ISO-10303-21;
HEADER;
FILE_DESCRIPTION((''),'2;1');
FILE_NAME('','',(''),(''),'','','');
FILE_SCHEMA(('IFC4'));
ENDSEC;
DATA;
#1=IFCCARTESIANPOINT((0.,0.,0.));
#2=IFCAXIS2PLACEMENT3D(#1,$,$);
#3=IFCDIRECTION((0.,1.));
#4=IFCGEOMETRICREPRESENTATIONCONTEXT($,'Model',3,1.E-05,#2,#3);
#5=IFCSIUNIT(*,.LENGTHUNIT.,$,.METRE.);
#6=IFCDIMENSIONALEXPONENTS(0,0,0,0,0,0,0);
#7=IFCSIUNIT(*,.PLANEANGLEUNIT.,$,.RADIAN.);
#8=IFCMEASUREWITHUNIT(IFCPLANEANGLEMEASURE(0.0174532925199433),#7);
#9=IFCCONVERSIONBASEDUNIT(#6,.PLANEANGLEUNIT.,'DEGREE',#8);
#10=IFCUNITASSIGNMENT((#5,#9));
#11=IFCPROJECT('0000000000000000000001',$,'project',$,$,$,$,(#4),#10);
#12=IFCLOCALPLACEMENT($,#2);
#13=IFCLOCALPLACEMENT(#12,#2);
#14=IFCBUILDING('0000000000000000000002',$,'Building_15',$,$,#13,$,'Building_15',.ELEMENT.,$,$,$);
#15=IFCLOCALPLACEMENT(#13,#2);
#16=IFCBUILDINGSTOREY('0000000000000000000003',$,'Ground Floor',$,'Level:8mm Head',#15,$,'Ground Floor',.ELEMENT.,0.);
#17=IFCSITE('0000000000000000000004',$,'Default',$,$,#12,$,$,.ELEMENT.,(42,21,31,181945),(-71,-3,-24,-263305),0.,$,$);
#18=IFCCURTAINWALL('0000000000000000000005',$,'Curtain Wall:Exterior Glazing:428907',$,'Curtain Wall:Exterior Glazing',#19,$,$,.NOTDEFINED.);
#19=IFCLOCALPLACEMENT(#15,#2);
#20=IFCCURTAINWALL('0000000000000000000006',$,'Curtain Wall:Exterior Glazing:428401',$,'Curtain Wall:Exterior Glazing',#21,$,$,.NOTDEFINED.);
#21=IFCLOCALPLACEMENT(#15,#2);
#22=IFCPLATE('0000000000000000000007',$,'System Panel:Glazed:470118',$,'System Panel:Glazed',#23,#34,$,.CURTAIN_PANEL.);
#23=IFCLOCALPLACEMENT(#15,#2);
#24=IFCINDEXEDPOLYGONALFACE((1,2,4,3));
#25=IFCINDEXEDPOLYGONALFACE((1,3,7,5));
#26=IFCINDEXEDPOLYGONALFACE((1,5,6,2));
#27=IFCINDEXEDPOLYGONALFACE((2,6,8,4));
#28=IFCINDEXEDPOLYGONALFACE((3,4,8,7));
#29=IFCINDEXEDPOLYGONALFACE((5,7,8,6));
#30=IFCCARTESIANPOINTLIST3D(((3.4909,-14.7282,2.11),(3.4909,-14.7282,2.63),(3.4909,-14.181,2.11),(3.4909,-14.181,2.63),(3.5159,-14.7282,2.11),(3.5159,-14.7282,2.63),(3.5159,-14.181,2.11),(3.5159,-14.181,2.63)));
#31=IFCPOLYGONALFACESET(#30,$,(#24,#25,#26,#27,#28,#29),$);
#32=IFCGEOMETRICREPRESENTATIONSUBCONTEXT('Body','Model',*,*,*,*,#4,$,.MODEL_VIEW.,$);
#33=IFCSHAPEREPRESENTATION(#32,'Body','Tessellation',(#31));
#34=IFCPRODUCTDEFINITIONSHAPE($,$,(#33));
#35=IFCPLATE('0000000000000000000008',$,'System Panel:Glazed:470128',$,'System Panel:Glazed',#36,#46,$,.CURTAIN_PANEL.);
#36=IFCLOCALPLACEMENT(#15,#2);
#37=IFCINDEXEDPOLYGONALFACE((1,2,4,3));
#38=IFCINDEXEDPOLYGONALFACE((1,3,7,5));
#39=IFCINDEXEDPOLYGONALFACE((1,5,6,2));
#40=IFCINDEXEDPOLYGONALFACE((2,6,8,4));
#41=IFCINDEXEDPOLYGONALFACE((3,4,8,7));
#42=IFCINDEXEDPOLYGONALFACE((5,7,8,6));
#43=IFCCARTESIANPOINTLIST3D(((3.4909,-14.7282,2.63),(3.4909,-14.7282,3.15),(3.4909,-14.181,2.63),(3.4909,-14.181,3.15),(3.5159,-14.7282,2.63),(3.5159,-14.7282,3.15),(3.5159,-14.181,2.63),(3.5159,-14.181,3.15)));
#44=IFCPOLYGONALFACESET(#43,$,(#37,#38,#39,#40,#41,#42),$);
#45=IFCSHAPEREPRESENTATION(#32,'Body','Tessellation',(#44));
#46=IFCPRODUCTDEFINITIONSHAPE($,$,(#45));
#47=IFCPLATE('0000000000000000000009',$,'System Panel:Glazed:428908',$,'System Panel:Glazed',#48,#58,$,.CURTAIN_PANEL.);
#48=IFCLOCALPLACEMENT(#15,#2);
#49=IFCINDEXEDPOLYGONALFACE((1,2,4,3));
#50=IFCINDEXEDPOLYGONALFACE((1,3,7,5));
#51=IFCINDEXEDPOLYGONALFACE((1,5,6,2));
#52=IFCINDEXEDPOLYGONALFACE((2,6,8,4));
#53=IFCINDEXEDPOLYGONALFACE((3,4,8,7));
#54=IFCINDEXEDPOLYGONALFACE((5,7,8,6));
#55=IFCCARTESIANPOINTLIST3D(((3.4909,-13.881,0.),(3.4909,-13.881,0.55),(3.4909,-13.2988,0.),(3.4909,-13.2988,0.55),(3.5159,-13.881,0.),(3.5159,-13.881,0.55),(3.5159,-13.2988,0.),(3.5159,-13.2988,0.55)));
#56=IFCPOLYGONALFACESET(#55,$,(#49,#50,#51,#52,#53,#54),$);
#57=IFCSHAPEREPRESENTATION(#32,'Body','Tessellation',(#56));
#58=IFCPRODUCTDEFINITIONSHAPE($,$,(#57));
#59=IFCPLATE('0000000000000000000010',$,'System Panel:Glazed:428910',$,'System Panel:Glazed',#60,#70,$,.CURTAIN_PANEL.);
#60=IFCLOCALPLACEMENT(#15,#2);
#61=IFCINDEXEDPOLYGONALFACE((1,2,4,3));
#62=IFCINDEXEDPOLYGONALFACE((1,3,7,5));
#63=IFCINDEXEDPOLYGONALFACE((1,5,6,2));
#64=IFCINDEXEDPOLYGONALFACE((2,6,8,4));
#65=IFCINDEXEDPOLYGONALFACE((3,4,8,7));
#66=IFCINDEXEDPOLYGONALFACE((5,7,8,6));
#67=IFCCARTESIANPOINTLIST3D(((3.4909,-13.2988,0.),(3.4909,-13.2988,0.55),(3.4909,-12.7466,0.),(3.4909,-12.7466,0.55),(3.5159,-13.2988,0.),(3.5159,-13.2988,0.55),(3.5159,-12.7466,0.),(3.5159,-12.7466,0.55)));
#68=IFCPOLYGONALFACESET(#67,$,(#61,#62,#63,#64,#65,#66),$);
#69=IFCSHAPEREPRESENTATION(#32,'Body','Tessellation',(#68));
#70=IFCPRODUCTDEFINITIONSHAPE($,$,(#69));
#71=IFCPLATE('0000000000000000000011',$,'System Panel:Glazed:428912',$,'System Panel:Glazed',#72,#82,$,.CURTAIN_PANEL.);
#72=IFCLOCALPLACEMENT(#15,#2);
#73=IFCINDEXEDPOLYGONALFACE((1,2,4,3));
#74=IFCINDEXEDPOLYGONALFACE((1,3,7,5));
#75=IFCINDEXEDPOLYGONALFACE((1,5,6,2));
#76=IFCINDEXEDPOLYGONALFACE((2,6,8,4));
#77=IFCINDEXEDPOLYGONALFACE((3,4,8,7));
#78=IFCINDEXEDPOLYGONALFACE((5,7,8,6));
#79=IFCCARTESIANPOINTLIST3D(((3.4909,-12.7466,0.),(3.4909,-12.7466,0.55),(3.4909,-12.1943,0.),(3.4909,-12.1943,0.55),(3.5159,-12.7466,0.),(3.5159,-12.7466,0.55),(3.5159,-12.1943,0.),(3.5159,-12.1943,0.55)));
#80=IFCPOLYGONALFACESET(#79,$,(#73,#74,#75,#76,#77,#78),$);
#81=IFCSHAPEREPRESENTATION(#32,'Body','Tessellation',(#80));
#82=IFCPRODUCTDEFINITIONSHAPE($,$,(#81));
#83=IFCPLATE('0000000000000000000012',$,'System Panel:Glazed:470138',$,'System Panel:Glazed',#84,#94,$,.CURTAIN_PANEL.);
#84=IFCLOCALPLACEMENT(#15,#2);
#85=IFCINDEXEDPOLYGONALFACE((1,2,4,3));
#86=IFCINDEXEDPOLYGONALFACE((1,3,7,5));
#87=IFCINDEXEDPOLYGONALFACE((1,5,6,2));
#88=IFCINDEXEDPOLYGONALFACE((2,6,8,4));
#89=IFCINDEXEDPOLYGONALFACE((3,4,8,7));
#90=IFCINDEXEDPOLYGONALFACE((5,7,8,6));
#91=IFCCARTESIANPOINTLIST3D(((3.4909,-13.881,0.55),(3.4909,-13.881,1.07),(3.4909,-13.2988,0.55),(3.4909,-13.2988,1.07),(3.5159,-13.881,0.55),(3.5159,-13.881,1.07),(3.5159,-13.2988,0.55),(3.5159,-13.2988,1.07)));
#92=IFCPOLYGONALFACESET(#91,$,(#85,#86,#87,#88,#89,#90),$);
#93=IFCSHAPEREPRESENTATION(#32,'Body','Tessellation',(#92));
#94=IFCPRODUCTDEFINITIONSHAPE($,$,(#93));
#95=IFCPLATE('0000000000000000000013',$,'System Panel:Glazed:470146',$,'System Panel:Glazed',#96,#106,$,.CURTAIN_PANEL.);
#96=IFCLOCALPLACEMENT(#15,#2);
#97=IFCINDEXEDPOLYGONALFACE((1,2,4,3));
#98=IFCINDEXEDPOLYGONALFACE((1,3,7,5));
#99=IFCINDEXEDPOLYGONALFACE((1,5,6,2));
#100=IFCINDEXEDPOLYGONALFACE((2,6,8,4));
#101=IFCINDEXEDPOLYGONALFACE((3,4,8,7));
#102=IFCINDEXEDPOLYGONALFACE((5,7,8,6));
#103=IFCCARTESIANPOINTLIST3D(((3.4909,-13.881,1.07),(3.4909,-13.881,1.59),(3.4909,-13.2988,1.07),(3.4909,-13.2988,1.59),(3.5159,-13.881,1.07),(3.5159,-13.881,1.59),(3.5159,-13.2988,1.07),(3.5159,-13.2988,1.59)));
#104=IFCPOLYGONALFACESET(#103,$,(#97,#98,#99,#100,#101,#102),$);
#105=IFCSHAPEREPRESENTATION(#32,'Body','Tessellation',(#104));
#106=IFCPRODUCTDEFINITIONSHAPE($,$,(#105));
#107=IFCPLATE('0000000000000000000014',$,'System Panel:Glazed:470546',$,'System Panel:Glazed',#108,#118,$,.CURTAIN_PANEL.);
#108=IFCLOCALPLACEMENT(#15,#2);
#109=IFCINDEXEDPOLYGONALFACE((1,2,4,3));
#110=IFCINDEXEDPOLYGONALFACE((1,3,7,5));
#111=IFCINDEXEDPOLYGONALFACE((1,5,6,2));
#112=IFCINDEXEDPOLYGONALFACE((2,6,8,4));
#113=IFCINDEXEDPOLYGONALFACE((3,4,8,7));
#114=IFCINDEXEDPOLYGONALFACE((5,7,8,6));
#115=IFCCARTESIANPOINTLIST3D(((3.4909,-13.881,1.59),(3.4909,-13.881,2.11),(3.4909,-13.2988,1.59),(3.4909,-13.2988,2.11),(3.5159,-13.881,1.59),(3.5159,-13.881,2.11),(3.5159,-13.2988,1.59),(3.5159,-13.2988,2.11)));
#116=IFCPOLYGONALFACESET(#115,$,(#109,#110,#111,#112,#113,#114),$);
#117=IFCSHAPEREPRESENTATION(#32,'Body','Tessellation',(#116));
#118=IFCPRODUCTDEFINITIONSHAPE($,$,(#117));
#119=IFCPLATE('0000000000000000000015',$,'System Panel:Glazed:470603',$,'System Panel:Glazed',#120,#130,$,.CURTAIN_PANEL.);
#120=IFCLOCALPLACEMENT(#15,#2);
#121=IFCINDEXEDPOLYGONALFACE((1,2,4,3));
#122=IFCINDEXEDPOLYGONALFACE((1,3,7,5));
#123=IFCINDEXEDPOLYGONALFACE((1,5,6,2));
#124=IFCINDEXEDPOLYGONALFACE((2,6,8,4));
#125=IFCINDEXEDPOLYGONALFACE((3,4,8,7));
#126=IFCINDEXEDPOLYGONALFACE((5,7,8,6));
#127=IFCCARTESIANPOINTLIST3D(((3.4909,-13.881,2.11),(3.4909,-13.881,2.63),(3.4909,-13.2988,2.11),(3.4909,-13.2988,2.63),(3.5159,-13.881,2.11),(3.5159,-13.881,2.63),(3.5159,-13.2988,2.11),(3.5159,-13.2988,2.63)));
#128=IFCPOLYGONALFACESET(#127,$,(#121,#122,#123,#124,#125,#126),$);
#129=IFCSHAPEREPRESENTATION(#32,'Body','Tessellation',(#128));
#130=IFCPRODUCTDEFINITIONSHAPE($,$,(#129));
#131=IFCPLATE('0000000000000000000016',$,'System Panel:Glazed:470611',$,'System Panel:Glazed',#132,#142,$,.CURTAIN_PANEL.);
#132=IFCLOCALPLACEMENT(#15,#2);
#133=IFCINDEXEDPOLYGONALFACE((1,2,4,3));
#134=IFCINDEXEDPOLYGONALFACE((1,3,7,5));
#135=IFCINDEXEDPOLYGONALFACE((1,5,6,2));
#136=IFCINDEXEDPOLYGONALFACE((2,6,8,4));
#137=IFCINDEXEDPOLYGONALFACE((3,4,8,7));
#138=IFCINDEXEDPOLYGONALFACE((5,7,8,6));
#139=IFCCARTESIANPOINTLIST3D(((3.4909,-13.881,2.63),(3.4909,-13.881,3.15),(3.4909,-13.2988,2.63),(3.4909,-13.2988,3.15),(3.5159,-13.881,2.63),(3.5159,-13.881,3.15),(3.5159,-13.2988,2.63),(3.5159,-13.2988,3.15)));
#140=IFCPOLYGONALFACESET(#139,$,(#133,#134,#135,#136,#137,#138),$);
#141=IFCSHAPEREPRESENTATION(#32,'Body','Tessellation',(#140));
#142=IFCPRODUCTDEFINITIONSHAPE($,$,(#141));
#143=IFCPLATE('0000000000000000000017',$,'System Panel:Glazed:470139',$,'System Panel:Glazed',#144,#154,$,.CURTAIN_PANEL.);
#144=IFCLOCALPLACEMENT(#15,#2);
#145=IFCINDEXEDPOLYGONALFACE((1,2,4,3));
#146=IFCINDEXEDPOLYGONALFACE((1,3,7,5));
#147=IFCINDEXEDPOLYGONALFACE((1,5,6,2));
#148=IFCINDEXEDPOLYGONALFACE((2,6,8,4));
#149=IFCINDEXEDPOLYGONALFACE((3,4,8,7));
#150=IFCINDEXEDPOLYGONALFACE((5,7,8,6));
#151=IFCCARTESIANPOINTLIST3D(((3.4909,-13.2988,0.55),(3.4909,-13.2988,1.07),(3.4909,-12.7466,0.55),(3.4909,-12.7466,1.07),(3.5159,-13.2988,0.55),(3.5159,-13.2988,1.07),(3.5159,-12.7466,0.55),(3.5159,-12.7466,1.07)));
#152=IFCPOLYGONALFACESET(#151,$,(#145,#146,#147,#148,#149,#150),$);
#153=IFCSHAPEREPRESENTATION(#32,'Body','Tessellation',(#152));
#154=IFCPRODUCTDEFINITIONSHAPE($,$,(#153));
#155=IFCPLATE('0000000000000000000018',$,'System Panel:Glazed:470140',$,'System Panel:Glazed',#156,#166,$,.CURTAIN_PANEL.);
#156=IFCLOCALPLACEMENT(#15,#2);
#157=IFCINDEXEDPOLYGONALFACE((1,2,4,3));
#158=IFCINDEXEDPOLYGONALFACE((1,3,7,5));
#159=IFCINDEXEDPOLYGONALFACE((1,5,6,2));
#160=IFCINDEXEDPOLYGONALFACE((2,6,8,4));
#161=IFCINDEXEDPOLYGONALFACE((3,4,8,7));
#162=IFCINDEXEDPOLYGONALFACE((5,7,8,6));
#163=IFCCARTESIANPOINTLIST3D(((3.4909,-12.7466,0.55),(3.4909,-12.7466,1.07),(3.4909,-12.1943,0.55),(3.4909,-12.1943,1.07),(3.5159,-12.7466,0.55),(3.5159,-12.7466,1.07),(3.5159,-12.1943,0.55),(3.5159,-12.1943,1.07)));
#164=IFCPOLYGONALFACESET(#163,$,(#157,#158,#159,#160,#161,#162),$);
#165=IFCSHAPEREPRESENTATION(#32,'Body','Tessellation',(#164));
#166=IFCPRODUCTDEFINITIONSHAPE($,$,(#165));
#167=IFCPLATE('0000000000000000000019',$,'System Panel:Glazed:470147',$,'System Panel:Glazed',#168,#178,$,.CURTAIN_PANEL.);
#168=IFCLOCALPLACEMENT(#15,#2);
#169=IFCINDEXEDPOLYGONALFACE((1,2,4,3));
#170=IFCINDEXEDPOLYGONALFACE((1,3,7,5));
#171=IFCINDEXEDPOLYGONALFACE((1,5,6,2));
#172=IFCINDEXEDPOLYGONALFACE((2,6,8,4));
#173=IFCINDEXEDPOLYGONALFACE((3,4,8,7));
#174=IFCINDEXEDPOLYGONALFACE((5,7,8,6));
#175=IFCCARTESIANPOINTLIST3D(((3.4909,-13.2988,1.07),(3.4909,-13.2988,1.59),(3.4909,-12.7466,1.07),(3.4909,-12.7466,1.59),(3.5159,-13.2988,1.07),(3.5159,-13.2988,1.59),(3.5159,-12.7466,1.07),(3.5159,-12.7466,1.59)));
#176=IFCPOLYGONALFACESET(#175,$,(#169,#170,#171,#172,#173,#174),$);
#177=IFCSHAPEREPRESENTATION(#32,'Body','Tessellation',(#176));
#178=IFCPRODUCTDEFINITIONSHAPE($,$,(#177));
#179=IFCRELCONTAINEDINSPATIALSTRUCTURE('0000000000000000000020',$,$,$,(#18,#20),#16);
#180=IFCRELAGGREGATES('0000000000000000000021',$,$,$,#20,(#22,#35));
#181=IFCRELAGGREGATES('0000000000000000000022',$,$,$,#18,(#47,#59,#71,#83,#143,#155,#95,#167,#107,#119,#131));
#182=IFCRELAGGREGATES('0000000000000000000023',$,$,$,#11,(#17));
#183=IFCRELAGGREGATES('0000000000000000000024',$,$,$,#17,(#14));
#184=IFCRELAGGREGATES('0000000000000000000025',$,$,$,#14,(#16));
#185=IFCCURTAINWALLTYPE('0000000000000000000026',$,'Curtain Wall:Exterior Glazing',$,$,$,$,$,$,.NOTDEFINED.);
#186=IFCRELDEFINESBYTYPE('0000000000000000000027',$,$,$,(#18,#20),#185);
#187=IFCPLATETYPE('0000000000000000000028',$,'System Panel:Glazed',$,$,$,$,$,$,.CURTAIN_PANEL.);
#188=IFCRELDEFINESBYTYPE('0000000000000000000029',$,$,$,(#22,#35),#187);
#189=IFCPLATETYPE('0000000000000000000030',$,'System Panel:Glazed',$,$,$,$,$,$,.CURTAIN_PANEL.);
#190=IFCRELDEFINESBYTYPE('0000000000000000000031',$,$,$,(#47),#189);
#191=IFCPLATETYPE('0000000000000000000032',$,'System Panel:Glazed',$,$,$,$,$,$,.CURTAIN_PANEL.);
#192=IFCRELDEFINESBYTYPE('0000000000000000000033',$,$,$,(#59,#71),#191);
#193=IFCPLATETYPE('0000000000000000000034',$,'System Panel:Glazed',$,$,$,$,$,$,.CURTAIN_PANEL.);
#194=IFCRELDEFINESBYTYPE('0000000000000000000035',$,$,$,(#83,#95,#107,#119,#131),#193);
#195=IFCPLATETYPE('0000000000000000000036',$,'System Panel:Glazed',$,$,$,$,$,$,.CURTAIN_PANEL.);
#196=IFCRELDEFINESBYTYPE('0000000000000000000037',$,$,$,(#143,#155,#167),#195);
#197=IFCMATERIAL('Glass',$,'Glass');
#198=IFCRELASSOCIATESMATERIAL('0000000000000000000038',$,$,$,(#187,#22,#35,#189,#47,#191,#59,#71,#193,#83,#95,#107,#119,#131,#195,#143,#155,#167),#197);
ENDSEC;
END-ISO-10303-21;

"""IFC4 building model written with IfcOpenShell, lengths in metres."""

from ifc_helpers import new_model, entity, si_unit, converted_unit, direction, frame, origin, place, context, subcontext, project, spatial, indexed_curve, outline, extrude, source, transform, mapped, material, type_object, type_shapes, element, aggregate, save


model = new_model("IFC4")

# Units and contexts
model_context = context("Model", 3, precision=1e-05, world=origin(), true_north=direction((0.0, 1.0)))
body_context = subcontext(model_context, "Body", "Model", "MODEL_VIEW")
ifc_project = project(units=[si_unit("LENGTHUNIT", "METRE"), converted_unit("PLANEANGLEUNIT", "DEGREE", entity("IfcPlaneAngleMeasure", 0.0174532925199433), si_unit("PLANEANGLEUNIT", "RADIAN"), dimensions=[0, 0, 0, 0, 0, 0, 0])], contexts=[model_context])

# Site, building, storey
site_placement = place(None, origin())
site = spatial("IfcSite", under=ifc_project, at=site_placement, Name="Default", CompositionType="ELEMENT", RefLatitude=(42, 21, 31, 181945), RefLongitude=(-71, -3, -24, -263305), RefElevation=0.0)
building_placement = place(site_placement, origin())
building = spatial("IfcBuilding", under=site, at=building_placement, Name="Building_15", LongName="Building_15", CompositionType="ELEMENT")
storey_placement = place(building_placement, origin())
storey = spatial("IfcBuildingStorey", under=building, at=storey_placement, Name="Ground Floor", ObjectType="Level:8mm Head", LongName="Ground Floor", CompositionType="ELEMENT", Elevation=0.0)

# Curtain wall
curtain_wall_type = type_object("IfcCurtainWallType", Name="Curtain Wall:Exterior Glazing", PredefinedType="NOTDEFINED")
curtain_wall_1_placement = place(storey_placement, origin())
curtain_wall_1 = element("IfcCurtainWall", 1, at=curtain_wall_1_placement, inside=storey, type_object=curtain_wall_type, Name="Curtain Wall:Exterior Glazing:428907", ObjectType="Curtain Wall:Exterior Glazing", PredefinedType="NOTDEFINED")

# Curtain wall, plates
curtain_wall_2_placement = place(storey_placement, origin())
curtain_wall_2 = element("IfcCurtainWall", 2, at=curtain_wall_2_placement, inside=storey, type_object=curtain_wall_type, Name="Curtain Wall:Exterior Glazing:428401", ObjectType="Curtain Wall:Exterior Glazing", PredefinedType="NOTDEFINED")
ifc_material_1 = material(Name="Glass", Category="Glass")
plate_type_1 = type_object("IfcPlateType", Name="System Panel:Glazed", PredefinedType="CURTAIN_PANEL", material=ifc_material_1)
shared_shape_1 = source(origin(), body_context, "Body", "SweptSolid", [
    extrude(outline(indexed_curve([(-0.0125, -0.2736), (0.0125, -0.2736), (0.0125, 0.2736), (-0.0125, 0.2736), (-0.0125, -0.2736)], self_intersect=False)), frame((0.0, 0.037, 0.0), z_axis=(0.0, 0.0, 1.0), x_axis=(0.0, 1.0, 0.0)), (0.0, 0.0, 1.0), 0.52),
])
type_shapes(plate_type_1, [shared_shape_1])
plate_1_placement = place(curtain_wall_2_placement, frame((3.5404, -14.4546, 2.11), z_axis=(0.0, 0.0, 1.0), x_axis=(0.0, 1.0, 0.0)))
plate_1 = element("IfcPlate", 3, at=plate_1_placement, type_object=plate_type_1, material=ifc_material_1, Name="System Panel:Glazed:470118", ObjectType="System Panel:Glazed", PredefinedType="CURTAIN_PANEL", context=body_context, shape_type="MappedRepresentation", body=[
    mapped(shared_shape_1, transform((0.0, 0.0, 0.0), scale=1.0)),
])
plate_2_placement = place(curtain_wall_2_placement, frame((3.5404, -14.4546, 2.63), z_axis=(0.0, 0.0, 1.0), x_axis=(0.0, 1.0, 0.0)))
plate_2 = element("IfcPlate", 4, at=plate_2_placement, type_object=plate_type_1, material=ifc_material_1, Name="System Panel:Glazed:470128", ObjectType="System Panel:Glazed", PredefinedType="CURTAIN_PANEL", context=body_context, shape_type="MappedRepresentation", body=[
    mapped(shared_shape_1, transform((0.0, 0.0, 0.0), scale=1.0)),
])
aggregate(curtain_wall_2, [plate_1, plate_2])

# Plates
plate_type_2 = type_object("IfcPlateType", Name="System Panel:Glazed", PredefinedType="CURTAIN_PANEL", material=ifc_material_1)
shared_shape_2 = source(origin(), body_context, "Body", "SweptSolid", [
    extrude(outline(indexed_curve([(-0.0125, -0.2911), (0.0125, -0.2911), (0.0125, 0.2911), (-0.0125, 0.2911), (-0.0125, -0.2911)], self_intersect=False)), frame((0.0, 0.037, 0.0), z_axis=(0.0, 0.0, 1.0), x_axis=(0.0, 1.0, 0.0)), (0.0, 0.0, 1.0), 0.55),
])
type_shapes(plate_type_2, [shared_shape_2])
plate_3_placement = place(curtain_wall_1_placement, frame((3.5404, -13.5899, 0.0), z_axis=(0.0, 0.0, 1.0), x_axis=(0.0, 1.0, 0.0)))
plate_3 = element("IfcPlate", 5, at=plate_3_placement, type_object=plate_type_2, material=ifc_material_1, Name="System Panel:Glazed:428908", ObjectType="System Panel:Glazed", PredefinedType="CURTAIN_PANEL", context=body_context, shape_type="MappedRepresentation", body=[
    mapped(shared_shape_2, transform((0.0, 0.0, 0.0), scale=1.0)),
])
plate_type_3 = type_object("IfcPlateType", Name="System Panel:Glazed", PredefinedType="CURTAIN_PANEL", material=ifc_material_1)
shared_shape_3 = source(origin(), body_context, "Body", "SweptSolid", [
    extrude(outline(indexed_curve([(-0.0125, -0.2761), (0.0125, -0.2761), (0.0125, 0.2761), (-0.0125, 0.2761), (-0.0125, -0.2761)], self_intersect=False)), frame((0.0, 0.037, 0.0), z_axis=(0.0, 0.0, 1.0), x_axis=(0.0, 1.0, 0.0)), (0.0, 0.0, 1.0), 0.55),
])
type_shapes(plate_type_3, [shared_shape_3])
plate_4_placement = place(curtain_wall_1_placement, frame((3.5404, -13.0227, 0.0), z_axis=(0.0, 0.0, 1.0), x_axis=(0.0, 1.0, 0.0)))
plate_4 = element("IfcPlate", 6, at=plate_4_placement, type_object=plate_type_3, material=ifc_material_1, Name="System Panel:Glazed:428910", ObjectType="System Panel:Glazed", PredefinedType="CURTAIN_PANEL", context=body_context, shape_type="MappedRepresentation", body=[
    mapped(shared_shape_3, transform((0.0, 0.0, 0.0), scale=1.0)),
])
plate_5_placement = place(curtain_wall_1_placement, frame((3.5404, -12.4705, 0.0), z_axis=(0.0, 0.0, 1.0), x_axis=(0.0, 1.0, 0.0)))
plate_5 = element("IfcPlate", 7, at=plate_5_placement, type_object=plate_type_3, material=ifc_material_1, Name="System Panel:Glazed:428912", ObjectType="System Panel:Glazed", PredefinedType="CURTAIN_PANEL", context=body_context, shape_type="MappedRepresentation", body=[
    mapped(shared_shape_3, transform((0.0, 0.0, 0.0), scale=1.0)),
])
plate_type_4 = type_object("IfcPlateType", Name="System Panel:Glazed", PredefinedType="CURTAIN_PANEL", material=ifc_material_1)
shared_shape_4 = source(origin(), body_context, "Body", "SweptSolid", [
    extrude(outline(indexed_curve([(-0.0125, -0.2911), (0.0125, -0.2911), (0.0125, 0.2911), (-0.0125, 0.2911), (-0.0125, -0.2911)], self_intersect=False)), frame((0.0, 0.037, 0.0), z_axis=(0.0, 0.0, 1.0), x_axis=(0.0, 1.0, 0.0)), (0.0, 0.0, 1.0), 0.52),
])
type_shapes(plate_type_4, [shared_shape_4])
plate_6_placement = place(curtain_wall_1_placement, frame((3.5404, -13.5899, 0.55), z_axis=(0.0, 0.0, 1.0), x_axis=(0.0, 1.0, 0.0)))
plate_6 = element("IfcPlate", 8, at=plate_6_placement, type_object=plate_type_4, material=ifc_material_1, Name="System Panel:Glazed:470138", ObjectType="System Panel:Glazed", PredefinedType="CURTAIN_PANEL", context=body_context, shape_type="MappedRepresentation", body=[
    mapped(shared_shape_4, transform((0.0, 0.0, 0.0), scale=1.0)),
])
plate_7_placement = place(curtain_wall_1_placement, frame((3.5404, -13.5899, 1.07), z_axis=(0.0, 0.0, 1.0), x_axis=(0.0, 1.0, 0.0)))
plate_7 = element("IfcPlate", 9, at=plate_7_placement, type_object=plate_type_4, material=ifc_material_1, Name="System Panel:Glazed:470146", ObjectType="System Panel:Glazed", PredefinedType="CURTAIN_PANEL", context=body_context, shape_type="MappedRepresentation", body=[
    mapped(shared_shape_4, transform((0.0, 0.0, 0.0), scale=1.0)),
])
plate_8_placement = place(curtain_wall_1_placement, frame((3.5404, -13.5899, 1.59), z_axis=(0.0, 0.0, 1.0), x_axis=(0.0, 1.0, 0.0)))
plate_8 = element("IfcPlate", 10, at=plate_8_placement, type_object=plate_type_4, material=ifc_material_1, Name="System Panel:Glazed:470546", ObjectType="System Panel:Glazed", PredefinedType="CURTAIN_PANEL", context=body_context, shape_type="MappedRepresentation", body=[
    mapped(shared_shape_4, transform((0.0, 0.0, 0.0), scale=1.0)),
])
plate_9_placement = place(curtain_wall_1_placement, frame((3.5404, -13.5899, 2.11), z_axis=(0.0, 0.0, 1.0), x_axis=(0.0, 1.0, 0.0)))
plate_9 = element("IfcPlate", 11, at=plate_9_placement, type_object=plate_type_4, material=ifc_material_1, Name="System Panel:Glazed:470603", ObjectType="System Panel:Glazed", PredefinedType="CURTAIN_PANEL", context=body_context, shape_type="MappedRepresentation", body=[
    mapped(shared_shape_4, transform((0.0, 0.0, 0.0), scale=1.0)),
])
plate_10_placement = place(curtain_wall_1_placement, frame((3.5404, -13.5899, 2.63), z_axis=(0.0, 0.0, 1.0), x_axis=(0.0, 1.0, 0.0)))
plate_10 = element("IfcPlate", 12, at=plate_10_placement, type_object=plate_type_4, material=ifc_material_1, Name="System Panel:Glazed:470611", ObjectType="System Panel:Glazed", PredefinedType="CURTAIN_PANEL", context=body_context, shape_type="MappedRepresentation", body=[
    mapped(shared_shape_4, transform((0.0, 0.0, 0.0), scale=1.0)),
])
plate_type_5 = type_object("IfcPlateType", Name="System Panel:Glazed", PredefinedType="CURTAIN_PANEL", material=ifc_material_1)
shared_shape_5 = source(origin(), body_context, "Body", "SweptSolid", [
    extrude(outline(indexed_curve([(-0.0125, -0.2761), (0.0125, -0.2761), (0.0125, 0.2761), (-0.0125, 0.2761), (-0.0125, -0.2761)], self_intersect=False)), frame((0.0, 0.037, 0.0), z_axis=(0.0, 0.0, 1.0), x_axis=(0.0, 1.0, 0.0)), (0.0, 0.0, 1.0), 0.52),
])
type_shapes(plate_type_5, [shared_shape_5])
plate_11_placement = place(curtain_wall_1_placement, frame((3.5404, -13.0227, 0.55), z_axis=(0.0, 0.0, 1.0), x_axis=(0.0, 1.0, 0.0)))
plate_11 = element("IfcPlate", 13, at=plate_11_placement, type_object=plate_type_5, material=ifc_material_1, Name="System Panel:Glazed:470139", ObjectType="System Panel:Glazed", PredefinedType="CURTAIN_PANEL", context=body_context, shape_type="MappedRepresentation", body=[
    mapped(shared_shape_5, transform((0.0, 0.0, 0.0), scale=1.0)),
])
plate_12_placement = place(curtain_wall_1_placement, frame((3.5404, -12.4705, 0.55), z_axis=(0.0, 0.0, 1.0), x_axis=(0.0, 1.0, 0.0)))
plate_12 = element("IfcPlate", 14, at=plate_12_placement, type_object=plate_type_5, material=ifc_material_1, Name="System Panel:Glazed:470140", ObjectType="System Panel:Glazed", PredefinedType="CURTAIN_PANEL", context=body_context, shape_type="MappedRepresentation", body=[
    mapped(shared_shape_5, transform((0.0, 0.0, 0.0), scale=1.0)),
])
plate_13_placement = place(curtain_wall_1_placement, frame((3.5404, -13.0227, 1.07), z_axis=(0.0, 0.0, 1.0), x_axis=(0.0, 1.0, 0.0)))
plate_13 = element("IfcPlate", 15, at=plate_13_placement, type_object=plate_type_5, material=ifc_material_1, Name="System Panel:Glazed:470147", ObjectType="System Panel:Glazed", PredefinedType="CURTAIN_PANEL", context=body_context, shape_type="MappedRepresentation", body=[
    mapped(shared_shape_5, transform((0.0, 0.0, 0.0), scale=1.0)),
])
aggregate(curtain_wall_1, [plate_3, plate_4, plate_5, plate_6, plate_11, plate_12, plate_7, plate_13, plate_8, plate_9, plate_10])

save(model, "model.ifc")
